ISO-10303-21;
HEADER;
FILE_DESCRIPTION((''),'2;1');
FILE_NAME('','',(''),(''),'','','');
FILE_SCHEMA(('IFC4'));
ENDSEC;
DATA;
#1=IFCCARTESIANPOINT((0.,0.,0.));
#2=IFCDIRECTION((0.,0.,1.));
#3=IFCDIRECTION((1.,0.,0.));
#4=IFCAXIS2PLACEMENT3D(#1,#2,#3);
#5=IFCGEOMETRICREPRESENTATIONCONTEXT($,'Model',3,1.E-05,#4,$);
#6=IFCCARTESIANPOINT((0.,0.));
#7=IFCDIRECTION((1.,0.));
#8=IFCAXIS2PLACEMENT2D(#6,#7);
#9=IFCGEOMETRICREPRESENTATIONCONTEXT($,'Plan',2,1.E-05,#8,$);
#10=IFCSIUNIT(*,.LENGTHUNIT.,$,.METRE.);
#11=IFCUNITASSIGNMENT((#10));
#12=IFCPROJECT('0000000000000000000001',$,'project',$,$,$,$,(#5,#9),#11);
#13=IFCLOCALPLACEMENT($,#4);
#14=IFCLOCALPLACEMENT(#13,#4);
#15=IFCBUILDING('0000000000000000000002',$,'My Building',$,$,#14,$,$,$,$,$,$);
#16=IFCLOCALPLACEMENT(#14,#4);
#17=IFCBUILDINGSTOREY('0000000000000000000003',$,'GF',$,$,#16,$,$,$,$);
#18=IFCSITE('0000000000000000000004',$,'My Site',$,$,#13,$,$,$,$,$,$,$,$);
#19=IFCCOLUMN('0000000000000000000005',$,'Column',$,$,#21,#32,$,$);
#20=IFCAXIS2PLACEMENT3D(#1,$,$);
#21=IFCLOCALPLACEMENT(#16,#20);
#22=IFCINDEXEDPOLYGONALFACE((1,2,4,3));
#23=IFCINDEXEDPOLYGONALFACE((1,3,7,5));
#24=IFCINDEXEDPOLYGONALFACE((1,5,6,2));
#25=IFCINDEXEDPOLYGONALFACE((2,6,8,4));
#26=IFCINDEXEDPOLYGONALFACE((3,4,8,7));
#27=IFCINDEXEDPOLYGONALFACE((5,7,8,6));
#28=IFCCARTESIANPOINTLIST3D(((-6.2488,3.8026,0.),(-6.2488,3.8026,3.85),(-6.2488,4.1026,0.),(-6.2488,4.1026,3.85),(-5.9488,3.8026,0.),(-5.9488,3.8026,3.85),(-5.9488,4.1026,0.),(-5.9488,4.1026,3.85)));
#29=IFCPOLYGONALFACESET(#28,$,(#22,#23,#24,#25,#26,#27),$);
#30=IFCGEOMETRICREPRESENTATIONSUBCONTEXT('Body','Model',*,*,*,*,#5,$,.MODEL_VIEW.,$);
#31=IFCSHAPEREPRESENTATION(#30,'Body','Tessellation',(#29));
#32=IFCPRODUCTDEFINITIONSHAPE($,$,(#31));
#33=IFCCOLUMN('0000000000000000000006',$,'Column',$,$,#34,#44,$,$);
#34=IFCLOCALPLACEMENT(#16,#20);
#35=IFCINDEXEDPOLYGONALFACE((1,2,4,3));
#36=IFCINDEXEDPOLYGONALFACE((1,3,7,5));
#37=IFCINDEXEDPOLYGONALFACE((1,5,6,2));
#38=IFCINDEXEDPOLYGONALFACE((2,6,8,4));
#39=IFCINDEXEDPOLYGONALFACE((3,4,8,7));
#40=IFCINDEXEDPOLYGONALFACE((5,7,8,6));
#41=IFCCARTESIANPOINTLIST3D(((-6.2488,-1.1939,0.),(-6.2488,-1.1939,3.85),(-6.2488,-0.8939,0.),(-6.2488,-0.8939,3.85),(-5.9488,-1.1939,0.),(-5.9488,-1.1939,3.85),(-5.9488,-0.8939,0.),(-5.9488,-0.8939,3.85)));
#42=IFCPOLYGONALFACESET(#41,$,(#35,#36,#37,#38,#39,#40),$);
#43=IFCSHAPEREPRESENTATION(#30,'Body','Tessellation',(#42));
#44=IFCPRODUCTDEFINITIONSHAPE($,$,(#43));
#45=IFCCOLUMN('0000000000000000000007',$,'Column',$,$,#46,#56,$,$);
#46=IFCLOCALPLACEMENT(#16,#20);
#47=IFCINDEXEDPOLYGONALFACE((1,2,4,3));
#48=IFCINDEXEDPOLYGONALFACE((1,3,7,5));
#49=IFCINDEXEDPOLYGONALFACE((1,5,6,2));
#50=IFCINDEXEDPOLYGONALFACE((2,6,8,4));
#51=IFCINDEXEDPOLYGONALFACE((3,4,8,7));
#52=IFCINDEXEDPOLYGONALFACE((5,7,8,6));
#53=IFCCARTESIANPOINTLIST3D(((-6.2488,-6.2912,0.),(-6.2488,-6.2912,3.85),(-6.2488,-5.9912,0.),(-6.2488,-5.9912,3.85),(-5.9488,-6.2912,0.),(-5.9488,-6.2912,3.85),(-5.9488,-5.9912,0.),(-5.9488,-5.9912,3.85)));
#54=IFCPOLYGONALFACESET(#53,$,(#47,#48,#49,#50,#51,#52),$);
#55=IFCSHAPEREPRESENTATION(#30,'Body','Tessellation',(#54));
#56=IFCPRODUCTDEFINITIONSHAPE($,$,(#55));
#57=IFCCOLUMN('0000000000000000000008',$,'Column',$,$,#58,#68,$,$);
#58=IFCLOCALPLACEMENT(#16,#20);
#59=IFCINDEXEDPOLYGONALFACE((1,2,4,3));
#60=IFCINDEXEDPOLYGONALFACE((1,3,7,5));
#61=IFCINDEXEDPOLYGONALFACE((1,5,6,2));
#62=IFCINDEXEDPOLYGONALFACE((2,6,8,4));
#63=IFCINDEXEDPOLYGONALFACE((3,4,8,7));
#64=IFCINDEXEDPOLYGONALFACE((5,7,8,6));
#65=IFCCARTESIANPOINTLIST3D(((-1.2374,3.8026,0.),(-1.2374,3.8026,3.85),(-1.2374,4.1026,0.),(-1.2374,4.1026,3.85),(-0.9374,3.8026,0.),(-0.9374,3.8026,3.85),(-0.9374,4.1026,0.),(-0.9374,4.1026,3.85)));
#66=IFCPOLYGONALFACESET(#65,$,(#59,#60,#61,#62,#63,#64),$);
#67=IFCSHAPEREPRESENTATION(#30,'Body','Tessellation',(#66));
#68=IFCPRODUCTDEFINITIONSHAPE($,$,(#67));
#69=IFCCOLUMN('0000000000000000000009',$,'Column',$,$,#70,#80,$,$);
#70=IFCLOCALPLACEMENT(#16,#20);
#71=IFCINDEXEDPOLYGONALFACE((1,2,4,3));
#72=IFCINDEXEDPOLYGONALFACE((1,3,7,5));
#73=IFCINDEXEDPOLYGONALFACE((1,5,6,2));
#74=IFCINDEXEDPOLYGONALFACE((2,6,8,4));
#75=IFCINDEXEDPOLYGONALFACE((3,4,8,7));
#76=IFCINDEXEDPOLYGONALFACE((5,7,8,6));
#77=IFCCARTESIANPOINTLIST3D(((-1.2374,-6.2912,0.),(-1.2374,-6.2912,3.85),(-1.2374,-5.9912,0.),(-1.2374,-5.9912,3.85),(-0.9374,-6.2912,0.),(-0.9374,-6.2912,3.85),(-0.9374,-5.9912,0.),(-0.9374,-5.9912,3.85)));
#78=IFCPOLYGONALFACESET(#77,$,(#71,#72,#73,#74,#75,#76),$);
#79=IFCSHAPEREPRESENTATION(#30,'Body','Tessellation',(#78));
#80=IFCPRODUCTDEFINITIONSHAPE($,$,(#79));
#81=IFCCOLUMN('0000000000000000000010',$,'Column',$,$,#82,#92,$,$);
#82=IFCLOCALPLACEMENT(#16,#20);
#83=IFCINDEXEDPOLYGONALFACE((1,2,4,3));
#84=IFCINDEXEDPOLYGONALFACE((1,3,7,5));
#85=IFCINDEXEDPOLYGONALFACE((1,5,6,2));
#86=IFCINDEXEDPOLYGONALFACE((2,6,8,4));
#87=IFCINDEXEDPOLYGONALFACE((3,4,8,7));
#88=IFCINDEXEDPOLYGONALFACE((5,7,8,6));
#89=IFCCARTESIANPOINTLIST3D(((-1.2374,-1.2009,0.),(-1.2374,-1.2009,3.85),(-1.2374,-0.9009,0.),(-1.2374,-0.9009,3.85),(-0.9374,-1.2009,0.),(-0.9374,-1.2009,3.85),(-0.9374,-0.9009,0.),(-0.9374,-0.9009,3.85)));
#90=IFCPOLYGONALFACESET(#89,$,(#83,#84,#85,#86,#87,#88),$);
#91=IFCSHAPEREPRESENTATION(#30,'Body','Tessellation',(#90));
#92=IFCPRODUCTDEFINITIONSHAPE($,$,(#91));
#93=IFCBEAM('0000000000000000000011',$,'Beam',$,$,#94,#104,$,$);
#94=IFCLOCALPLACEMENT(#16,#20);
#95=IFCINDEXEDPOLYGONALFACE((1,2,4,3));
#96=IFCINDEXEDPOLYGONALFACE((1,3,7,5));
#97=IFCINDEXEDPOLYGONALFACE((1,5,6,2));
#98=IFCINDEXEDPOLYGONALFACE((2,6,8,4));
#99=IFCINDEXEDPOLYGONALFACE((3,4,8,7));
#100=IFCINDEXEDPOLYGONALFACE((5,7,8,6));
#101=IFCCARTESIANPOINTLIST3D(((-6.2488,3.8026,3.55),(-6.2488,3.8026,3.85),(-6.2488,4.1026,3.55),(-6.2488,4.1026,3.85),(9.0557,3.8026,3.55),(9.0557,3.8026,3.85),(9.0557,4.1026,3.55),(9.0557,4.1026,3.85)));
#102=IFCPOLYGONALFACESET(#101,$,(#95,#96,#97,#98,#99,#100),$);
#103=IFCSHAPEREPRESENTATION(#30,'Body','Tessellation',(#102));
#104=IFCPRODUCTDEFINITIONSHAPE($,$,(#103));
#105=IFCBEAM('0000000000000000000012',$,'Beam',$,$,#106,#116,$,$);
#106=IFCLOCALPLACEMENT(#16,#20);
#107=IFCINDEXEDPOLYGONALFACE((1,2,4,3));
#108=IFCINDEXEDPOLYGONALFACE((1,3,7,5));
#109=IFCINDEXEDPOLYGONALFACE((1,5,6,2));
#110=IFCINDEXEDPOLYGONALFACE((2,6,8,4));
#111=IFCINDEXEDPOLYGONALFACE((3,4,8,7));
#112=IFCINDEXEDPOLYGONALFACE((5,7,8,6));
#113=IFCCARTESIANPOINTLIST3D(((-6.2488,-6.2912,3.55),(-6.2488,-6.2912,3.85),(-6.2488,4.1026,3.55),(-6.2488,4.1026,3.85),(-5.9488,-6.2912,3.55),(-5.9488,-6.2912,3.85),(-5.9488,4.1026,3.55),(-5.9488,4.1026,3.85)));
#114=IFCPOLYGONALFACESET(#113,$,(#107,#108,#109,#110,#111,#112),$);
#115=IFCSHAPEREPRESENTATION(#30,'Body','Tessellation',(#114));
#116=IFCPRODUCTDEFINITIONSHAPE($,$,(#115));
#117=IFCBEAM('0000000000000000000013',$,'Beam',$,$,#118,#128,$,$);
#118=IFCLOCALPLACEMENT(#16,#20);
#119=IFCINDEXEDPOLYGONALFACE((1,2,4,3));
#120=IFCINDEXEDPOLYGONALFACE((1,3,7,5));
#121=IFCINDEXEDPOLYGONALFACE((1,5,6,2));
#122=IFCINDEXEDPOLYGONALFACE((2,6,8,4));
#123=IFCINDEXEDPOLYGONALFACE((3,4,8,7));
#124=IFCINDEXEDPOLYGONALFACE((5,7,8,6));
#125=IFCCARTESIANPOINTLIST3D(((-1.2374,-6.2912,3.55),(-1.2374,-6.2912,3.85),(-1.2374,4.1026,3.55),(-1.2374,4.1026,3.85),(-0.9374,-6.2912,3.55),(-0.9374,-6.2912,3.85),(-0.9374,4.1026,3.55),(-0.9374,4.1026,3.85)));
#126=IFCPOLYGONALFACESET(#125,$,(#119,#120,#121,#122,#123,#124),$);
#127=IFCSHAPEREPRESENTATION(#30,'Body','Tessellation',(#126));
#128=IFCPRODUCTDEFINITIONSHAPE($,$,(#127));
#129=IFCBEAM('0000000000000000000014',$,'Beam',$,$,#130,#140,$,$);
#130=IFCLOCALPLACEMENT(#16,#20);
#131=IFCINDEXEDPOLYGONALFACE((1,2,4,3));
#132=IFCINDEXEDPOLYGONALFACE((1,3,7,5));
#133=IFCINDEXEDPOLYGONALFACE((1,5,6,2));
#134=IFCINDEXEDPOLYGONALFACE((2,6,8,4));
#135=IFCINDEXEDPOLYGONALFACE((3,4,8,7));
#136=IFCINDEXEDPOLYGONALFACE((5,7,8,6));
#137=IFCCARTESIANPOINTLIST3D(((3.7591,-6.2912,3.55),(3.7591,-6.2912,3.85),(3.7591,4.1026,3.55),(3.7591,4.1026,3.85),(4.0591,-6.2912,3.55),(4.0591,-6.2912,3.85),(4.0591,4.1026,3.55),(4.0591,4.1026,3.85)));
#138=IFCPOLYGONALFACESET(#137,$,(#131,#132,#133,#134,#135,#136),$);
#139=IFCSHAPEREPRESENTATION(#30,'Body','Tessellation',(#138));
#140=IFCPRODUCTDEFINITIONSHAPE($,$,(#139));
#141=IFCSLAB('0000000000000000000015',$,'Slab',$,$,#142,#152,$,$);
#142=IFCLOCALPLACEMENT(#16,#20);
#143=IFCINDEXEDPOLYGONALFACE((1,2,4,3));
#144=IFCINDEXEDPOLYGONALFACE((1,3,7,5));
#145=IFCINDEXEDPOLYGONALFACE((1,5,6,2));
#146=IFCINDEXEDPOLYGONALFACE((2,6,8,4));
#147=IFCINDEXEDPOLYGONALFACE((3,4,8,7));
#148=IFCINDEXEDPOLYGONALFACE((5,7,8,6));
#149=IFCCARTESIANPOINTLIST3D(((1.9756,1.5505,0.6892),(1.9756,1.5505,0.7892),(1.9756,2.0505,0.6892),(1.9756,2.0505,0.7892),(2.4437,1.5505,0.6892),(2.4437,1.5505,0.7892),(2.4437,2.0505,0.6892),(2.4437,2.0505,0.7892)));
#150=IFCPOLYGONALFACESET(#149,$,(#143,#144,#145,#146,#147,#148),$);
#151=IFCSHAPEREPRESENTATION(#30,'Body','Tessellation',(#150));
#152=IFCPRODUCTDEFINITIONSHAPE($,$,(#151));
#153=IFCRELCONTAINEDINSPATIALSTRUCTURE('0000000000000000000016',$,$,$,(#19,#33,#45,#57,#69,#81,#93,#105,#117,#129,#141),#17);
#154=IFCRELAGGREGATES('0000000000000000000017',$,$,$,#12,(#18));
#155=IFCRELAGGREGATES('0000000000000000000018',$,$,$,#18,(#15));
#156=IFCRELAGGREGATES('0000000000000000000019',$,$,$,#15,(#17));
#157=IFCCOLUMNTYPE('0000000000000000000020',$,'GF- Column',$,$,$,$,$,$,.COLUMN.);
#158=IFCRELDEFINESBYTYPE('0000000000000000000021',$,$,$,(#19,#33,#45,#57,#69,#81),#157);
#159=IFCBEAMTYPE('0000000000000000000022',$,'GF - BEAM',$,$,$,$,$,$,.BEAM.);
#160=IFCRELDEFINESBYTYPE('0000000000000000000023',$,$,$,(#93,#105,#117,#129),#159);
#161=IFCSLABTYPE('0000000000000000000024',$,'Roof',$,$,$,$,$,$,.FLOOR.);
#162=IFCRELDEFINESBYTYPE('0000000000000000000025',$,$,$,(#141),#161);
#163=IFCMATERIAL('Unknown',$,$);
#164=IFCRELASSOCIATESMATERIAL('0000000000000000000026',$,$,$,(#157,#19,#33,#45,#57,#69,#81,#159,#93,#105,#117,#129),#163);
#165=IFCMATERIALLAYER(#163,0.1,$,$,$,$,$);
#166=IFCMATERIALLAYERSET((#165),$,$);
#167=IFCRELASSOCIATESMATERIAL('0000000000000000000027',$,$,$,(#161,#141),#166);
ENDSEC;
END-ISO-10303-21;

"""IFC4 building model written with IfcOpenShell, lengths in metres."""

from ifc_helpers import new_model, si_unit, frame, origin_with_axes, origin_2d_with_axis, place, context, subcontext, project, spatial, indexed_curve, rectangle, outline, extrude, material, layer, layer_set, layer_usage, material_profile, profile_set, profile_usage, type_object, element, save


model = new_model("IFC4")

# Units and contexts
model_context = context("Model", 3, precision=1e-05, world=origin_with_axes())
plan_context = context("Plan", 2, precision=1e-05, world=origin_2d_with_axis())
body_context_1 = subcontext(model_context, "Body", "Model", "MODEL_VIEW")
ifc_project = project(units=[si_unit("LENGTHUNIT", "METRE")], contexts=[model_context, plan_context])

# Site, building, storey
site_placement = place(None, origin_with_axes())
site = spatial("IfcSite", under=ifc_project, at=site_placement, Name="My Site")
building_placement = place(site_placement, origin_with_axes())
building = spatial("IfcBuilding", under=site, at=building_placement, Name="My Building")
storey_placement = place(building_placement, origin_with_axes())
storey = spatial("IfcBuildingStorey", under=building, at=storey_placement, Name="GF")

# Columns
ifc_material = material(Name="Unknown")
ifc_material_profile_1 = material_profile(ifc_material, rectangle(XDim=0.3, YDim=0.3))
ifc_profile_set_1 = profile_set([ifc_material_profile_1])
ifc_profile_usage_1 = profile_usage(ifc_profile_set_1, cardinal=5)
column_type = type_object("IfcColumnType", Name="GF- Column", PredefinedType="COLUMN", material=ifc_profile_set_1)
column_1_placement = place(storey_placement, frame((-6.0988, 3.9526, 0.0), z_axis=(0.0, 0.0, 1.0), x_axis=(1.0, 0.0, 0.0)))
element("IfcColumn", 1, at=column_1_placement, inside=storey, type_object=column_type, material=ifc_profile_usage_1, Name="Column", context=body_context_1, shape_type="SweptSolid", body=[
    extrude(rectangle(XDim=0.3, YDim=0.3), origin_with_axes(), (0.0, 0.0, 1.0), 3.85),
])
ifc_profile_usage_2 = profile_usage(ifc_profile_set_1, cardinal=5)
column_2_placement = place(storey_placement, frame((-6.0988, -1.0439, 0.0), z_axis=(0.0, 0.0, 1.0), x_axis=(1.0, 0.0, 0.0)))
element("IfcColumn", 2, at=column_2_placement, inside=storey, type_object=column_type, material=ifc_profile_usage_2, Name="Column", context=body_context_1, shape_type="SweptSolid", body=[
    extrude(rectangle(XDim=0.3, YDim=0.3), origin_with_axes(), (0.0, 0.0, 1.0), 3.85),
])
ifc_profile_usage_3 = profile_usage(ifc_profile_set_1, cardinal=5)
column_3_placement = place(storey_placement, frame((-6.0988, -6.1412, 0.0), z_axis=(0.0, 0.0, 1.0), x_axis=(1.0, 0.0, 0.0)))
element("IfcColumn", 3, at=column_3_placement, inside=storey, type_object=column_type, material=ifc_profile_usage_3, Name="Column", context=body_context_1, shape_type="SweptSolid", body=[
    extrude(rectangle(XDim=0.3, YDim=0.3), origin_with_axes(), (0.0, 0.0, 1.0), 3.85),
])
ifc_profile_usage_4 = profile_usage(ifc_profile_set_1, cardinal=5)
column_4_placement = place(storey_placement, frame((-1.0874, 3.9526, 0.0), z_axis=(0.0, 0.0, 1.0), x_axis=(1.0, 0.0, 0.0)))
element("IfcColumn", 4, at=column_4_placement, inside=storey, type_object=column_type, material=ifc_profile_usage_4, Name="Column", context=body_context_1, shape_type="SweptSolid", body=[
    extrude(rectangle(XDim=0.3, YDim=0.3), origin_with_axes(), (0.0, 0.0, 1.0), 3.85),
])
ifc_profile_usage_5 = profile_usage(ifc_profile_set_1, cardinal=5)
column_5_placement = place(storey_placement, frame((-1.0874, -6.1412, 0.0), z_axis=(0.0, 0.0, 1.0), x_axis=(1.0, 0.0, 0.0)))
element("IfcColumn", 5, at=column_5_placement, inside=storey, type_object=column_type, material=ifc_profile_usage_5, Name="Column", context=body_context_1, shape_type="SweptSolid", body=[
    extrude(rectangle(XDim=0.3, YDim=0.3), origin_with_axes(), (0.0, 0.0, 1.0), 3.85),
])
ifc_profile_usage_6 = profile_usage(ifc_profile_set_1, cardinal=5)
column_6_placement = place(storey_placement, frame((-1.0874, -1.0509, 0.0), z_axis=(0.0, 0.0, 1.0), x_axis=(1.0, 0.0, 0.0)))
element("IfcColumn", 6, at=column_6_placement, inside=storey, type_object=column_type, material=ifc_profile_usage_6, Name="Column", context=body_context_1, shape_type="SweptSolid", body=[
    extrude(rectangle(XDim=0.3, YDim=0.3), origin_with_axes(), (0.0, 0.0, 1.0), 3.85),
])

# Beams
ifc_material_profile_2 = material_profile(ifc_material, rectangle(XDim=0.3, YDim=0.3))
ifc_profile_set_2 = profile_set([ifc_material_profile_2])
ifc_profile_usage_7 = profile_usage(ifc_profile_set_2, cardinal=5)
beam_type = type_object("IfcBeamType", Name="GF - BEAM", PredefinedType="BEAM", material=ifc_profile_set_2)
beam_1_placement = place(storey_placement, frame((-6.2488, 3.9526, 3.7), z_axis=(1.0, 0.0, 0.000001), x_axis=(0.0, 1.0, 0.0)))
element("IfcBeam", 7, at=beam_1_placement, inside=storey, type_object=beam_type, material=ifc_profile_usage_7, Name="Beam", context=body_context_1, shape_type="SweptSolid", body=[
    extrude(rectangle(XDim=0.3, YDim=0.3), origin_with_axes(), (0.0, 0.0, 1.0), 15.3045),
])
ifc_profile_usage_8 = profile_usage(ifc_profile_set_2, cardinal=5)
beam_2_placement = place(storey_placement, frame((-6.0988, -6.2912, 3.7), z_axis=(0.0, 1.0, 0.0), x_axis=(-1.0, 0.0, 0.0)))
element("IfcBeam", 8, at=beam_2_placement, inside=storey, type_object=beam_type, material=ifc_profile_usage_8, Name="Beam", context=body_context_1, shape_type="SweptSolid", body=[
    extrude(rectangle(XDim=0.3, YDim=0.3), origin_with_axes(), (0.0, 0.0, 1.0), 10.3938),
])
ifc_profile_usage_9 = profile_usage(ifc_profile_set_2, cardinal=5)
beam_3_placement = place(storey_placement, frame((-1.0874, -6.2912, 3.7), z_axis=(0.0, 1.0, 0.0), x_axis=(-1.0, 0.0, 0.0)))
element("IfcBeam", 9, at=beam_3_placement, inside=storey, type_object=beam_type, material=ifc_profile_usage_9, Name="Beam", context=body_context_1, shape_type="SweptSolid", body=[
    extrude(rectangle(XDim=0.3, YDim=0.3), origin_with_axes(), (0.0, 0.0, 1.0), 10.3938),
])
ifc_profile_usage_10 = profile_usage(ifc_profile_set_2, cardinal=5)
beam_4_placement = place(storey_placement, frame((3.9091, -6.2912, 3.7), z_axis=(0.0, 1.0, 0.0), x_axis=(-1.0, 0.0, 0.0)))
element("IfcBeam", 10, at=beam_4_placement, inside=storey, type_object=beam_type, material=ifc_profile_usage_10, Name="Beam", context=body_context_1, shape_type="SweptSolid", body=[
    extrude(rectangle(XDim=0.3, YDim=0.3), origin_with_axes(), (0.0, 0.0, 1.0), 10.3938),
])

# Slab
ifc_layer_1 = layer(ifc_material, 0.1)
ifc_layer_set_1 = layer_set([ifc_layer_1])
ifc_layer_usage_1 = layer_usage(ifc_layer_set_1, "AXIS3", "POSITIVE", -0.1)
slab_type = type_object("IfcSlabType", Name="Roof", PredefinedType="FLOOR", material=ifc_layer_set_1)
slab_placement = place(storey_placement, frame((2.4437, 2.0505, 0.7892), z_axis=(0.0, 0.0, 1.0), x_axis=(1.0, 0.0, 0.0)))
element("IfcSlab", 11, at=slab_placement, inside=storey, type_object=slab_type, material=ifc_layer_usage_1, Name="Slab", context=body_context_1, shape_type="SweptSolid", body=[
    extrude(outline(indexed_curve([(0.0, 0.0), (-0.468, 0.0), (-0.468, -0.5), (0.0, -0.5), (0.0, 0.0)])), frame((0.0, 0.0, -0.1), z_axis=(0.0, 0.0, 1.0), x_axis=(1.0, 0.0, 0.0)), (0.0, 0.0, 1.0), 0.1),
])

save(model, "model.ifc")
